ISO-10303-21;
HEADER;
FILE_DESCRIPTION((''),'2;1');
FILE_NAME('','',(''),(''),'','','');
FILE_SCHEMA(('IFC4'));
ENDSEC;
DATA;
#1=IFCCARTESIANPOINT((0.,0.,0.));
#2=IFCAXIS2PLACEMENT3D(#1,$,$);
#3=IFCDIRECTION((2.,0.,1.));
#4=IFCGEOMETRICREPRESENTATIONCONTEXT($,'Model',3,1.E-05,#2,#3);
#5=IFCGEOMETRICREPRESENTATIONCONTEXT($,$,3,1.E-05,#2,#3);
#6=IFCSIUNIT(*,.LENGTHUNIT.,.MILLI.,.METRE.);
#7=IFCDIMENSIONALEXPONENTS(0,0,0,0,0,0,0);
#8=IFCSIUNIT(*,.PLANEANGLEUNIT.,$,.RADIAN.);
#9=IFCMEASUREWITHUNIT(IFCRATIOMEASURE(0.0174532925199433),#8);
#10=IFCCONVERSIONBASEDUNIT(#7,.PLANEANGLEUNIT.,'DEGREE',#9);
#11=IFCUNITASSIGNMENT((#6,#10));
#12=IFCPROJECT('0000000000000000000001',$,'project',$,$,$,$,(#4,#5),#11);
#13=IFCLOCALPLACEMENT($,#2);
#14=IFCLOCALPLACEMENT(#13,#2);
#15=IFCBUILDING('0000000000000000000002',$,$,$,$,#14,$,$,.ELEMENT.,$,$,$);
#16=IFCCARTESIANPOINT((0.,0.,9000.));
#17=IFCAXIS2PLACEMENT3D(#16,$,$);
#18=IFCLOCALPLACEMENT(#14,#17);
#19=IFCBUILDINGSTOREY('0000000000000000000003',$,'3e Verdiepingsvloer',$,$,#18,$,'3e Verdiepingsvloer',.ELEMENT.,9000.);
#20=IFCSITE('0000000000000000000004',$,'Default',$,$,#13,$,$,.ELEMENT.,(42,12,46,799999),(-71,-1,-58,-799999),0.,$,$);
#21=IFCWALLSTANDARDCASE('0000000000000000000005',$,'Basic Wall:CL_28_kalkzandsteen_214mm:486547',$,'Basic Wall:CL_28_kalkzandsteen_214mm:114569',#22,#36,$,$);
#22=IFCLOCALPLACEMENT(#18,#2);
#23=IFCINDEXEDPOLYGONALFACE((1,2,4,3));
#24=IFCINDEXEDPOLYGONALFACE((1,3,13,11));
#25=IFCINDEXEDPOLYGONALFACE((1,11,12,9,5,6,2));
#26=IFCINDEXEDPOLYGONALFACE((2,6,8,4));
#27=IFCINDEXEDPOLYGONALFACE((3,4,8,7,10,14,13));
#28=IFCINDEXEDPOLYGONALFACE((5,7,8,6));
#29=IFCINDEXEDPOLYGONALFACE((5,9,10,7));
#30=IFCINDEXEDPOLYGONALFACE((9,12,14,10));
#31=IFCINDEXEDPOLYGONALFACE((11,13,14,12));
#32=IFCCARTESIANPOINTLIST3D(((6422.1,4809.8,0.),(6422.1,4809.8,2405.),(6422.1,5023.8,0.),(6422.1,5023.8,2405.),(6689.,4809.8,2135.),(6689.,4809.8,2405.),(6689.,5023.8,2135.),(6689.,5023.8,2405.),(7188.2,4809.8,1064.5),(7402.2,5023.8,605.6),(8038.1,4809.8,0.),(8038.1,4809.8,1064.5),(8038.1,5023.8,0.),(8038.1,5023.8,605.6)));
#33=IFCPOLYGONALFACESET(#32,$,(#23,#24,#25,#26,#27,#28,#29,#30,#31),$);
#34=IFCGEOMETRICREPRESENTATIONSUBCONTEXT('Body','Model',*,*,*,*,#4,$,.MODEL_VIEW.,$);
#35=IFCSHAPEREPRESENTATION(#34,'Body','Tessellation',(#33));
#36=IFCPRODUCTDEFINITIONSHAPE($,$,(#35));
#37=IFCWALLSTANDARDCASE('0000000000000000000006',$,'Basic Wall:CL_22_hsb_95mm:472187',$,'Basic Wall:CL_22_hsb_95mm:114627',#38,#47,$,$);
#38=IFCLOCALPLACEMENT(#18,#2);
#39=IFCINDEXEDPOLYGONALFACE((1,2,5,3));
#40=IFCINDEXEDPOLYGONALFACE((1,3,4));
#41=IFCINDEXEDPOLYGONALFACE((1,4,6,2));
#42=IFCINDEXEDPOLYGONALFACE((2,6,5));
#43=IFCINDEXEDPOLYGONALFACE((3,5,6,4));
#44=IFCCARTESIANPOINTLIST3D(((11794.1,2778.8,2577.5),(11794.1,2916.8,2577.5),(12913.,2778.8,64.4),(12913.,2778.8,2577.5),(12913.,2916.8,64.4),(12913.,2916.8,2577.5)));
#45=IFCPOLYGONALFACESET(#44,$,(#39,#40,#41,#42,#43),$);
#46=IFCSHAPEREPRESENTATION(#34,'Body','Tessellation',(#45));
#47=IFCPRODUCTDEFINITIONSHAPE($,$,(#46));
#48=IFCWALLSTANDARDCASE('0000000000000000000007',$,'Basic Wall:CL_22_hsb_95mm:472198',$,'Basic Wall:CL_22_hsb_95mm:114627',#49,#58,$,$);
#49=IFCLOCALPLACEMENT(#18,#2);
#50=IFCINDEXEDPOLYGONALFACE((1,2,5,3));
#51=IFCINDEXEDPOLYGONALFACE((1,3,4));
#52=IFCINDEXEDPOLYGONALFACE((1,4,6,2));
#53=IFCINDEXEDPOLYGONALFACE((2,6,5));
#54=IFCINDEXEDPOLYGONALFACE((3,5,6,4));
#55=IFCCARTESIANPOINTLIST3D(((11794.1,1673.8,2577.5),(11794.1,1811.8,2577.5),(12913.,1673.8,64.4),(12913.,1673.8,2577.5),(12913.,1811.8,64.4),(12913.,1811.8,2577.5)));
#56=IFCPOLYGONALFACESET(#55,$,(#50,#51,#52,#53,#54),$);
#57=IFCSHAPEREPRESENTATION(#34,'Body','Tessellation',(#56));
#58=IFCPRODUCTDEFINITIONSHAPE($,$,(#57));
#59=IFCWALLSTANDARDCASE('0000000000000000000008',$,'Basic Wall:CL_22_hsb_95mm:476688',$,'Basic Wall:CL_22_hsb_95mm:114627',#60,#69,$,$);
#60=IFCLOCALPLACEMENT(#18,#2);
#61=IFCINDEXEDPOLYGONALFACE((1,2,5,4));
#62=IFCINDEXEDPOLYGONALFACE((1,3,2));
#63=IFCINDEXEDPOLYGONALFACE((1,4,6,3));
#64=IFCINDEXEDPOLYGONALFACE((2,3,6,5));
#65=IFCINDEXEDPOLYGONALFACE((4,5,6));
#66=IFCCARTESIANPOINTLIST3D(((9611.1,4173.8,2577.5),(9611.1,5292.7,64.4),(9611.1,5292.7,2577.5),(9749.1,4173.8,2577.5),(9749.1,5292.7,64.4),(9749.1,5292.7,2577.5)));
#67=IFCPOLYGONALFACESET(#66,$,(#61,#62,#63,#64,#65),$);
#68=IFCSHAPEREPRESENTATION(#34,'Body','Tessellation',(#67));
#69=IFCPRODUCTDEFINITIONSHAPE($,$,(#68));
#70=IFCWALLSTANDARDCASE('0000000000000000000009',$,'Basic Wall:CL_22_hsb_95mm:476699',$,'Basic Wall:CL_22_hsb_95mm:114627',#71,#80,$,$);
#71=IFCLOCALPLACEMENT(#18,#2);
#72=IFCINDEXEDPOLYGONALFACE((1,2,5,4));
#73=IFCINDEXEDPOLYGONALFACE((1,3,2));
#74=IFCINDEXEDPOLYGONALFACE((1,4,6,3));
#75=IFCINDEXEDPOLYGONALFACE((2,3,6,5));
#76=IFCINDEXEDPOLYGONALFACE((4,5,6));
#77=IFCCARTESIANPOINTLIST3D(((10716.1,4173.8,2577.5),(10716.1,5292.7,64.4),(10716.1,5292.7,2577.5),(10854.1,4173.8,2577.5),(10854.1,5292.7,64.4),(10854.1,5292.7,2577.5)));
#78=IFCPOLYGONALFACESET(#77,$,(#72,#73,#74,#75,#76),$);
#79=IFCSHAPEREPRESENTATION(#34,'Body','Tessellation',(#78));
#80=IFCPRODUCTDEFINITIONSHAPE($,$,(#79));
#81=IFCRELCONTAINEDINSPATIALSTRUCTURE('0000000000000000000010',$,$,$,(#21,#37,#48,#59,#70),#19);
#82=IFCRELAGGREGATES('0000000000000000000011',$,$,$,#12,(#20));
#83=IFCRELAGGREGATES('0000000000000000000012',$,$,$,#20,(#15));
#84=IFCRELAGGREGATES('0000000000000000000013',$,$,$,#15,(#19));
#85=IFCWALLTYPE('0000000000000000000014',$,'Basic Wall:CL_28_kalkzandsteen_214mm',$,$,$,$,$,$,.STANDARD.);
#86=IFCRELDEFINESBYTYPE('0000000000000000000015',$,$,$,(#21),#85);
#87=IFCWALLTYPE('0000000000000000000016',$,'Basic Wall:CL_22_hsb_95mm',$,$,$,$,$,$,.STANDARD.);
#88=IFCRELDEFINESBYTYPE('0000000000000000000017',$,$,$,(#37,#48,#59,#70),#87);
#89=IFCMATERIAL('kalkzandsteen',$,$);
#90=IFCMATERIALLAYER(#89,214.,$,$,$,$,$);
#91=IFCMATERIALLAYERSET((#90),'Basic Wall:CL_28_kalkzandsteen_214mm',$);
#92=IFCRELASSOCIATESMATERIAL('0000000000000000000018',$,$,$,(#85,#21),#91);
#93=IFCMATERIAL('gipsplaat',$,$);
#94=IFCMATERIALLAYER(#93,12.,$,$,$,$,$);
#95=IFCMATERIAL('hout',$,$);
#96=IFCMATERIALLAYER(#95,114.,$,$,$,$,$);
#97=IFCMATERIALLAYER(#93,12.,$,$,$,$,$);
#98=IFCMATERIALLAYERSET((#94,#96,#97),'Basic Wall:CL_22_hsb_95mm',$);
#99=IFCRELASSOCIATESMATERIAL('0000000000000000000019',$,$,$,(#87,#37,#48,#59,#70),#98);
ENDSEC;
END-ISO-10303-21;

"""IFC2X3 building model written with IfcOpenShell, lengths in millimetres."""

from ifc_helpers import new_model, entity, si_unit, converted_unit, direction, frame, frame_2d, origin, place, context, subcontext, project, spatial, polyline, rectangle, extrude, clip, halfspace, bounded_halfspace, material, layer, layer_set, layer_usage, type_object, element, save


model = new_model("IFC2X3")

# Units and contexts
model_context = context("Model", 3, precision=1e-05, world=origin(), true_north=direction((2.0, 0.0, 1.0)))
context_of_model = context(None, 3, precision=1e-05, world=origin(), true_north=direction((2.0, 0.0, 1.0)))
body_context = subcontext(model_context, "Body", "Model", "MODEL_VIEW")
ifc_project = project(units=[si_unit("LENGTHUNIT", "METRE", prefix="MILLI"), converted_unit("PLANEANGLEUNIT", "DEGREE", entity("IfcRatioMeasure", 0.0174532925199433), si_unit("PLANEANGLEUNIT", "RADIAN"), dimensions=[0, 0, 0, 0, 0, 0, 0])], contexts=[model_context, context_of_model])

# Site, building, storey
site_placement = place(None, origin())
site = spatial("IfcSite", under=ifc_project, at=site_placement, Name="Default", CompositionType="ELEMENT", RefLatitude=(42, 12, 46, 799999), RefLongitude=(-71, -1, -58, -799999), RefElevation=0.0)
building_placement = place(site_placement, origin())
building = spatial("IfcBuilding", under=site, at=building_placement, CompositionType="ELEMENT")
storey_placement = place(building_placement, frame((0.0, 0.0, 9000.0)))
storey = spatial("IfcBuildingStorey", under=building, at=storey_placement, Name="3e Verdiepingsvloer", LongName="3e Verdiepingsvloer", CompositionType="ELEMENT", Elevation=9000.0)

# Shared definitions
ifc_material_1 = material(Name="hout")

# Walls
ifc_material_2 = material(Name="kalkzandsteen")
ifc_layer_1 = layer(ifc_material_2, 214.0)
ifc_layer_set_1 = layer_set([ifc_layer_1], Name="Basic Wall:CL_28_kalkzandsteen_214mm")
ifc_layer_usage_1 = layer_usage(ifc_layer_set_1, "AXIS2", "NEGATIVE", 107.0)
wall_type_1 = type_object("IfcWallType", Name="Basic Wall:CL_28_kalkzandsteen_214mm", PredefinedType="STANDARD", material=ifc_layer_set_1)
wall_1_placement = place(storey_placement, frame((8038.1, 4916.8, 0.0), z_axis=(0.0, 0.0, 1.0), x_axis=(-1.0, 0.0, 0.0)))
element("IfcWallStandardCase", 1, at=wall_1_placement, inside=storey, type_object=wall_type_1, material=ifc_layer_usage_1, Name="Basic Wall:CL_28_kalkzandsteen_214mm:486547", ObjectType="Basic Wall:CL_28_kalkzandsteen_214mm:114569", context=body_context, shape_type="Clipping", body=[
    clip(clip(clip(extrude(rectangle(XDim=1616.0, YDim=214.0, at=frame_2d((808.0, 0.0), x_axis=(-1.0, 0.0))), origin(), (0.0, 0.0, 1.0), 2640.0), bounded_halfspace(frame((1349.1, -107.0, 2405.0), z_axis=(0.0, 0.0, 1.0), x_axis=(-1.0, 0.0, 0.0)), False, frame((1349.1, -107.0, 2405.0)), polyline([(0.0, 0.0), (266.9, 0.0), (266.9, 214.0), (0.0, 214.0), (0.0, 0.0)]))), bounded_halfspace(frame((0.0, -107.0, 605.6), z_axis=(0.0, -0.906308, 0.422618), x_axis=(1.0, 0.0, 0.0)), False, frame((0.0, -107.0, 605.6)), polyline([(0.0, 0.0), (635.9, 0.0), (849.9, 214.0), (0.0, 214.0), (0.0, 0.0)]))), bounded_halfspace(frame((635.9, -107.0, 605.6), z_axis=(-0.906308, 0.0, 0.422618), x_axis=(0.0, -1.0, 0.0)), False, frame((635.9, -107.0, 605.6)), polyline([(0.0, 0.0), (713.2, 0.0), (713.2, 214.0), (214.0, 214.0), (0.0, 0.0)]))),
])
ifc_material_3 = material(Name="gipsplaat")
ifc_layer_2 = layer(ifc_material_3, 12.0)
ifc_layer_3 = layer(ifc_material_1, 114.0)
ifc_layer_4 = layer(ifc_material_3, 12.0)
ifc_layer_set_2 = layer_set([ifc_layer_2, ifc_layer_3, ifc_layer_4], Name="Basic Wall:CL_22_hsb_95mm")
ifc_layer_usage_2 = layer_usage(ifc_layer_set_2, "AXIS2", "NEGATIVE", 69.0)
wall_type_2 = type_object("IfcWallType", Name="Basic Wall:CL_22_hsb_95mm", PredefinedType="STANDARD", material=ifc_layer_set_2)
wall_2_placement = place(storey_placement, frame((11794.1, 2847.8, 0.0)))
element("IfcWallStandardCase", 2, at=wall_2_placement, inside=storey, type_object=wall_type_2, material=ifc_layer_usage_2, Name="Basic Wall:CL_22_hsb_95mm:472187", ObjectType="Basic Wall:CL_22_hsb_95mm:114627", context=body_context, shape_type="Clipping", body=[
    clip(clip(extrude(rectangle(XDim=1118.9, YDim=138.0, at=frame_2d((559.5, 0.0), x_axis=(-1.0, 0.0))), origin(), (0.0, 0.0, 1.0), 2860.0), halfspace(frame((1118.9, -69.0, 64.4), z_axis=(-0.913545, 0.0, -0.406737), x_axis=(0.0, 1.0, 0.0)), False)), halfspace(frame((0.0, -69.0, 2577.5), z_axis=(0.0, 0.0, 1.0), x_axis=(0.0, 1.0, 0.0)), False)),
])
ifc_layer_usage_3 = layer_usage(ifc_layer_set_2, "AXIS2", "NEGATIVE", 69.0)
wall_3_placement = place(storey_placement, frame((11794.1, 1742.8, 0.0)))
element("IfcWallStandardCase", 3, at=wall_3_placement, inside=storey, type_object=wall_type_2, material=ifc_layer_usage_3, Name="Basic Wall:CL_22_hsb_95mm:472198", ObjectType="Basic Wall:CL_22_hsb_95mm:114627", context=body_context, shape_type="Clipping", body=[
    clip(clip(extrude(rectangle(XDim=1118.9, YDim=138.0, at=frame_2d((559.5, 0.0), x_axis=(-1.0, 0.0))), origin(), (0.0, 0.0, 1.0), 2860.0), halfspace(frame((1118.9, -69.0, 64.4), z_axis=(-0.913545, 0.0, -0.406737), x_axis=(0.0, 1.0, 0.0)), False)), halfspace(frame((0.0, -69.0, 2577.5), z_axis=(0.0, 0.0, 1.0), x_axis=(0.0, 1.0, 0.0)), False)),
])
ifc_layer_usage_4 = layer_usage(ifc_layer_set_2, "AXIS2", "NEGATIVE", 69.0)
wall_4_placement = place(storey_placement, frame((9680.1, 4173.8, 0.0), z_axis=(0.0, 0.0, 1.0), x_axis=(0.0, 1.0, 0.0)))
element("IfcWallStandardCase", 4, at=wall_4_placement, inside=storey, type_object=wall_type_2, material=ifc_layer_usage_4, Name="Basic Wall:CL_22_hsb_95mm:476688", ObjectType="Basic Wall:CL_22_hsb_95mm:114627", context=body_context, shape_type="Clipping", body=[
    clip(clip(extrude(rectangle(XDim=1118.9, YDim=138.0, at=frame_2d((559.5, 0.0), x_axis=(-1.0, 0.0))), origin(), (0.0, 0.0, 1.0), 2860.0), halfspace(frame((1118.9, -69.0, 64.4), z_axis=(-0.913545, 0.0, -0.406737), x_axis=(0.0, 1.0, 0.0)), False)), halfspace(frame((0.0, -69.0, 2577.5), z_axis=(0.0, 0.0, 1.0), x_axis=(0.0, 1.0, 0.0)), False)),
])
ifc_layer_usage_5 = layer_usage(ifc_layer_set_2, "AXIS2", "NEGATIVE", 69.0)
wall_5_placement = place(storey_placement, frame((10785.1, 4173.8, 0.0), z_axis=(0.0, 0.0, 1.0), x_axis=(0.0, 1.0, 0.0)))
element("IfcWallStandardCase", 5, at=wall_5_placement, inside=storey, type_object=wall_type_2, material=ifc_layer_usage_5, Name="Basic Wall:CL_22_hsb_95mm:476699", ObjectType="Basic Wall:CL_22_hsb_95mm:114627", context=body_context, shape_type="Clipping", body=[
    clip(clip(extrude(rectangle(XDim=1118.9, YDim=138.0, at=frame_2d((559.5, 0.0), x_axis=(-1.0, 0.0))), origin(), (0.0, 0.0, 1.0), 2860.0), halfspace(frame((1118.9, -69.0, 64.4), z_axis=(-0.913545, 0.0, -0.406737), x_axis=(0.0, 1.0, 0.0)), False)), halfspace(frame((0.0, -69.0, 2577.5), z_axis=(0.0, 0.0, 1.0), x_axis=(0.0, 1.0, 0.0)), False)),
])

save(model, "model.ifc")
